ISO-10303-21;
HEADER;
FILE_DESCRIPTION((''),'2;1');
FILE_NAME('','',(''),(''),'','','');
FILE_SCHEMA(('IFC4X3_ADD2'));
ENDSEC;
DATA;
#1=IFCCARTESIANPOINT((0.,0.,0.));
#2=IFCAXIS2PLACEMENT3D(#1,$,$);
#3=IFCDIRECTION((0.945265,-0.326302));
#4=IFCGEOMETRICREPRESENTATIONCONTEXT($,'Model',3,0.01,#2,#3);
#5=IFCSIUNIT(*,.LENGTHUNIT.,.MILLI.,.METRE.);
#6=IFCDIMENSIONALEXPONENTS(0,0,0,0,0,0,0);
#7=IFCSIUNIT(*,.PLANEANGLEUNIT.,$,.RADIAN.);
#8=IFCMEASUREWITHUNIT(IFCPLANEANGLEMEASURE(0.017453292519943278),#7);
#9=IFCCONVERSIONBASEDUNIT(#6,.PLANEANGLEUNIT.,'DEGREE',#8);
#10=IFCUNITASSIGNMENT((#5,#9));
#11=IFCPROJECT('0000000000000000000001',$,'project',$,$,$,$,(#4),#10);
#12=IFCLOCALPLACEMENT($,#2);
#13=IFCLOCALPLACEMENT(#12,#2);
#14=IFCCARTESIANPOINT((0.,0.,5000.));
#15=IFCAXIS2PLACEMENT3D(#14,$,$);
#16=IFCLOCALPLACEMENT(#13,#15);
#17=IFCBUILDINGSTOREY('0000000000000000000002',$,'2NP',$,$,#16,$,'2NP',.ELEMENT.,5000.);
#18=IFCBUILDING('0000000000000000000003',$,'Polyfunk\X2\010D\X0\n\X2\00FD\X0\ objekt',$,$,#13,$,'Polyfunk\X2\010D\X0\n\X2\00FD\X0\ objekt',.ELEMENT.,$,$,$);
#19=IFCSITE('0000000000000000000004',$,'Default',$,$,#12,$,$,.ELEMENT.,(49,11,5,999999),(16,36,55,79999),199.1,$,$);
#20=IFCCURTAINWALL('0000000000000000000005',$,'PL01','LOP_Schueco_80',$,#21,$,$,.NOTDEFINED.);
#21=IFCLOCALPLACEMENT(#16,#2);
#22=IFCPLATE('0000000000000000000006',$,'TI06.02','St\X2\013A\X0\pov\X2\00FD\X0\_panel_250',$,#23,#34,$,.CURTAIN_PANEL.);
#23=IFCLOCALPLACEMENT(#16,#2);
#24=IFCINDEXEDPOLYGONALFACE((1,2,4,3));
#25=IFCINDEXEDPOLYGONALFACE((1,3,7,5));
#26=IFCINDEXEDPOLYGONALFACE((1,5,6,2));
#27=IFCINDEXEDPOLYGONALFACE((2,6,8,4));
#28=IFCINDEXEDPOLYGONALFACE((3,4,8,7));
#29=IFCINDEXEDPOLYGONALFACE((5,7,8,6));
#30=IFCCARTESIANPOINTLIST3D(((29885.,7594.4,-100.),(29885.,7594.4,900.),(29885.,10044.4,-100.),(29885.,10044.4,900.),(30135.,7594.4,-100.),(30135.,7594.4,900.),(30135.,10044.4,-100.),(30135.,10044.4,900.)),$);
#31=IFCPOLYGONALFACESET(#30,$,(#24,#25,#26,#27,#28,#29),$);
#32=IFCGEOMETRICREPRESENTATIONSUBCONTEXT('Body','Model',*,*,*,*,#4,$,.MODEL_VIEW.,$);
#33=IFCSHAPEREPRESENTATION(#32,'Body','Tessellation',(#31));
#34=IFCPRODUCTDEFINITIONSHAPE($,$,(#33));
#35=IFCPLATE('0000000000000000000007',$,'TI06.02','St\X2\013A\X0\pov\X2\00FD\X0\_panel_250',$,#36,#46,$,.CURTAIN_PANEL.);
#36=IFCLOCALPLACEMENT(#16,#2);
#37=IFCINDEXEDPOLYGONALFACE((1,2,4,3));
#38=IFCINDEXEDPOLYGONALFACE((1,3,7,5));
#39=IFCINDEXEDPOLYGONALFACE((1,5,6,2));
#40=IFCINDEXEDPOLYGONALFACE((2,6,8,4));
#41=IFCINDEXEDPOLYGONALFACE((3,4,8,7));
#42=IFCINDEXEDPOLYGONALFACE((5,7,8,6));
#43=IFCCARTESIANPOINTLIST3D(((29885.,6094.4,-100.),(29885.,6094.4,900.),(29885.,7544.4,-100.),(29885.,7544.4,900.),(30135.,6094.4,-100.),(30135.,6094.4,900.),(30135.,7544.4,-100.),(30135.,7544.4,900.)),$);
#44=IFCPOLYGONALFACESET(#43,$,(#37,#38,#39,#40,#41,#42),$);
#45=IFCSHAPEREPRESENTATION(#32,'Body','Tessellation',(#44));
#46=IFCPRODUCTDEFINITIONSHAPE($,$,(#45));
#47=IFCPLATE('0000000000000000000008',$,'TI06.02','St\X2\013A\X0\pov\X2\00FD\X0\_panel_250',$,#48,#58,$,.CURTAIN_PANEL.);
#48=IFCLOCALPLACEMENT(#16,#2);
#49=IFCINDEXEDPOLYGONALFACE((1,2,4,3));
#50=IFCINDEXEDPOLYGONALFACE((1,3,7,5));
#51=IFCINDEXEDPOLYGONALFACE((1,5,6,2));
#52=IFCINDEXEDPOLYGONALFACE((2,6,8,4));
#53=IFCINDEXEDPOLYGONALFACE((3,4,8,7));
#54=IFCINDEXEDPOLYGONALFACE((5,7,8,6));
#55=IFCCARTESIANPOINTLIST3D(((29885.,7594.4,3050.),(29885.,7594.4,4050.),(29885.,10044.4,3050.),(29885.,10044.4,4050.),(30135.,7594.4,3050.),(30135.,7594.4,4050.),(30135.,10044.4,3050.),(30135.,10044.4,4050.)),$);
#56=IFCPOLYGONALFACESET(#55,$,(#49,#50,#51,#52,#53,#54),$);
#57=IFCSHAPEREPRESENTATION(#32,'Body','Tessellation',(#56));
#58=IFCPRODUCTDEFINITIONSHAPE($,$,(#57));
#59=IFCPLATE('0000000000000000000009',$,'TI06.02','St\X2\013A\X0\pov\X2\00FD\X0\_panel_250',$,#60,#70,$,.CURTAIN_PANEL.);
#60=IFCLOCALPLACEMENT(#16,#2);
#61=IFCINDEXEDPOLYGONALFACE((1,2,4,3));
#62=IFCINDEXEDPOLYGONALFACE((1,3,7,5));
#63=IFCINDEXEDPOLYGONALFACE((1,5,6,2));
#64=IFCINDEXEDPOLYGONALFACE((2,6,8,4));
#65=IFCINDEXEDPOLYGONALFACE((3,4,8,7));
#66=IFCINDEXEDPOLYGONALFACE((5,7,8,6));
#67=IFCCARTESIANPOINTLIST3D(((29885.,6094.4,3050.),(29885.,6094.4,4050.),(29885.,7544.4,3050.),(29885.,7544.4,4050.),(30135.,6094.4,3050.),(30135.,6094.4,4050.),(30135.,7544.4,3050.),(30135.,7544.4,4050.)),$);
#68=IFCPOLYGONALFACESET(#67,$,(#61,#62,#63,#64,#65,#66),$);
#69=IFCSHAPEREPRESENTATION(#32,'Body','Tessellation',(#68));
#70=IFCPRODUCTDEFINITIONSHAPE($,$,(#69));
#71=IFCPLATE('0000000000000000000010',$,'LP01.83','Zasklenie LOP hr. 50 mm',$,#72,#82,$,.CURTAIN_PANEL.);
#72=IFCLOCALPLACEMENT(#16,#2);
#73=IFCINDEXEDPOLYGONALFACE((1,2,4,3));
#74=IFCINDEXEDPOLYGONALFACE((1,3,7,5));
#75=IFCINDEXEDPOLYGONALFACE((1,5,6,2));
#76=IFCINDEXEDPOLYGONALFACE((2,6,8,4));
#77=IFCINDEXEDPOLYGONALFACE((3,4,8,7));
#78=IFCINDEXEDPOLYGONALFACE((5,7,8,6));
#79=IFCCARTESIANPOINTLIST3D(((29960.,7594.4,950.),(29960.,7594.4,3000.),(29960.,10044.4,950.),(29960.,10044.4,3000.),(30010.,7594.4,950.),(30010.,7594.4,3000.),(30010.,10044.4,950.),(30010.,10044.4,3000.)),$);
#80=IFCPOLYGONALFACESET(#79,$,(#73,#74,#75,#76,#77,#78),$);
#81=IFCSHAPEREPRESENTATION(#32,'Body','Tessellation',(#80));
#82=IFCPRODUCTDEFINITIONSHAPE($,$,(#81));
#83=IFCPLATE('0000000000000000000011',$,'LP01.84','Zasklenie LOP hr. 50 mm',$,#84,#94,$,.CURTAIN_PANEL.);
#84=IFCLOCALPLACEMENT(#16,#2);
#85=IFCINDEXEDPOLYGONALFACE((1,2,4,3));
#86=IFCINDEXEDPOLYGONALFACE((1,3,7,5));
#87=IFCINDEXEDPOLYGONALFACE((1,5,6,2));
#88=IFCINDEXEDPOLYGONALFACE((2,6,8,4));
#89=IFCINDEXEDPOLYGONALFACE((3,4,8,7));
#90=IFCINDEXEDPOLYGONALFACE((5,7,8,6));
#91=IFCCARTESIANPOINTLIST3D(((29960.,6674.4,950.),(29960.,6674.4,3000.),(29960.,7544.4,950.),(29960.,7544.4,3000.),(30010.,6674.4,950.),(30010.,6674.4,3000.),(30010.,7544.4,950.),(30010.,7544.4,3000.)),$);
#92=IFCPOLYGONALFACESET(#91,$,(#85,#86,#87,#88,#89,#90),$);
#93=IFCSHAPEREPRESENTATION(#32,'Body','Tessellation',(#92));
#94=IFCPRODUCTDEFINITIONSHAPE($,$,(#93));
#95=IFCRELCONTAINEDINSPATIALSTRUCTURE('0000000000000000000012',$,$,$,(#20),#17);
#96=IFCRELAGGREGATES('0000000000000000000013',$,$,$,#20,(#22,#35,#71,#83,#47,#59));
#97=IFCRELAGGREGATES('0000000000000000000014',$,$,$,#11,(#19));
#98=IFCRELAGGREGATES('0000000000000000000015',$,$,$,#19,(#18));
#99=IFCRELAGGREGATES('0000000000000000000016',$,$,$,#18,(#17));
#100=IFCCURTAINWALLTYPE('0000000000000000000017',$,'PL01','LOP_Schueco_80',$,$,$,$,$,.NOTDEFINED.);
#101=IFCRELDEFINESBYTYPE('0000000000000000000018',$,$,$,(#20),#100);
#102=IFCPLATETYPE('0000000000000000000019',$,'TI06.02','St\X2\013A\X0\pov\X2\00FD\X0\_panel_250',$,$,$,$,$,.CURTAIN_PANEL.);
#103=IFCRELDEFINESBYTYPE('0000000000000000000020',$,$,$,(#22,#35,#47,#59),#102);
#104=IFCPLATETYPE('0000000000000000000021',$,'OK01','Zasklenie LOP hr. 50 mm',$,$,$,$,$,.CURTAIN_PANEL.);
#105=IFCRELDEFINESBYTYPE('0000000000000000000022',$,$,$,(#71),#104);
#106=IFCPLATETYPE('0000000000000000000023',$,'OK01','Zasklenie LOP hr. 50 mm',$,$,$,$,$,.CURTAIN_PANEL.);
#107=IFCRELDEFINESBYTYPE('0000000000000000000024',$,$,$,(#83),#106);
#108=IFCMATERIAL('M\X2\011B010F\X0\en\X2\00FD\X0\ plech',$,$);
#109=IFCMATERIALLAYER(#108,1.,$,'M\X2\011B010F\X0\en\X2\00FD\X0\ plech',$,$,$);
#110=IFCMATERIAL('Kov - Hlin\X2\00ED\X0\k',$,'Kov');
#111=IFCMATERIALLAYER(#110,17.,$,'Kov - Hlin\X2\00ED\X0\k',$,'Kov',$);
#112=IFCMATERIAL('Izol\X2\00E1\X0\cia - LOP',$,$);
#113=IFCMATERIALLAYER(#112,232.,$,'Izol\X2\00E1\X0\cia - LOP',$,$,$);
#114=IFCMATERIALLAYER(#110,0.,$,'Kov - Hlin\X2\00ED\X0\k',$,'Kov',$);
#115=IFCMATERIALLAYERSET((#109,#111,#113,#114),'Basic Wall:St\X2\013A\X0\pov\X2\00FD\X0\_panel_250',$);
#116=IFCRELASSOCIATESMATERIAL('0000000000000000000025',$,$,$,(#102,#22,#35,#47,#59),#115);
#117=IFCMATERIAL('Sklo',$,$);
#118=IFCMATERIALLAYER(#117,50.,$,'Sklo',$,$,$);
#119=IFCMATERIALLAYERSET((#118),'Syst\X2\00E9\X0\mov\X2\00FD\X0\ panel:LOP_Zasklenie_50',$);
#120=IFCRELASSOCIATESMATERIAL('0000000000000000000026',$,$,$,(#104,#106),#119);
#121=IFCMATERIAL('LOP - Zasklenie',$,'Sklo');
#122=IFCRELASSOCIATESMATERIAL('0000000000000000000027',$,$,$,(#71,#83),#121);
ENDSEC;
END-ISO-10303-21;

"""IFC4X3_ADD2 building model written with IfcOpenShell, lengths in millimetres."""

from ifc_helpers import new_model, entity, si_unit, converted_unit, direction, frame, frame_2d, origin, origin_2d_with_axis, place, context, subcontext, project, spatial, rectangle, extrude, source, transform, mapped, material, layer, layer_set, layer_usage, type_object, type_shapes, element, aggregate, save


model = new_model("IFC4X3_ADD2")

# Units and contexts
model_context = context("Model", 3, precision=0.01, world=origin(), true_north=direction((0.945265, -0.326302)))
body_context = subcontext(model_context, "Body", "Model", "MODEL_VIEW")
ifc_project = project(units=[si_unit("LENGTHUNIT", "METRE", prefix="MILLI"), converted_unit("PLANEANGLEUNIT", "DEGREE", entity("IfcPlaneAngleMeasure", 0.017453292519943278), si_unit("PLANEANGLEUNIT", "RADIAN"), dimensions=[0, 0, 0, 0, 0, 0, 0])], contexts=[model_context])

# Site, building, storey
site_placement = place(None, origin())
site = spatial("IfcSite", under=ifc_project, at=site_placement, Name="Default", CompositionType="ELEMENT", RefLatitude=(49, 11, 5, 999999), RefLongitude=(16, 36, 55, 79999), RefElevation=199.1)
building_placement = place(site_placement, origin())
building = spatial("IfcBuilding", under=site, at=building_placement, Name="Polyfunkčný objekt", LongName="Polyfunkčný objekt", CompositionType="ELEMENT")
storey_placement = place(building_placement, frame((0.0, 0.0, 5000.0)))
storey = spatial("IfcBuildingStorey", under=building, at=storey_placement, Name="2NP", LongName="2NP", CompositionType="ELEMENT", Elevation=5000.0)

# Curtain wall, plates
curtain_wall_type = type_object("IfcCurtainWallType", Name="PL01", Description="LOP_Schueco_80", PredefinedType="NOTDEFINED")
curtain_wall_placement = place(storey_placement, frame((0.0, 0.0, -5000.0)))
curtain_wall = element("IfcCurtainWall", 1, at=curtain_wall_placement, inside=storey, type_object=curtain_wall_type, Name="PL01", Description="LOP_Schueco_80", PredefinedType="NOTDEFINED")
ifc_material_1 = material(Name="Měďený plech")
ifc_layer_1 = layer(ifc_material_1, 1.0, Name="Měďený plech")
ifc_material_2 = material(Name="Kov - Hliník", Category="Kov")
ifc_layer_2 = layer(ifc_material_2, 17.0, Name="Kov - Hliník", Category="Kov")
ifc_material_3 = material(Name="Izolácia - LOP")
ifc_layer_3 = layer(ifc_material_3, 232.0, Name="Izolácia - LOP")
ifc_layer_4 = layer(ifc_material_2, 0.0, Name="Kov - Hliník", Category="Kov")
ifc_layer_set_1 = layer_set([ifc_layer_1, ifc_layer_2, ifc_layer_3, ifc_layer_4], Name="Basic Wall:Stĺpový_panel_250")
ifc_layer_usage_1 = layer_usage(ifc_layer_set_1, "AXIS2", "POSITIVE", -125.0)
plate_type_1 = type_object("IfcPlateType", Name="TI06.02", Description="Stĺpový_panel_250", PredefinedType="CURTAIN_PANEL", material=ifc_layer_set_1)
plate_1_placement = place(storey_placement, frame((30010.0, 10044.4, -100.0), z_axis=(0.0, 0.0, 1.0), x_axis=(0.0, -1.0, 0.0)))
plate_1 = element("IfcPlate", 2, at=plate_1_placement, type_object=plate_type_1, material=ifc_layer_usage_1, Name="TI06.02", Description="Stĺpový_panel_250", PredefinedType="CURTAIN_PANEL", context=body_context, shape_type="SweptSolid", body=[
    extrude(rectangle(XDim=250.0, YDim=2450.0, at=origin_2d_with_axis()), frame((1225.0, 0.0, 0.0), z_axis=(0.0, 0.0, 1.0), x_axis=(0.0, 1.0, 0.0)), (0.0, 0.0, 1.0), 1000.0),
])
ifc_layer_usage_2 = layer_usage(ifc_layer_set_1, "AXIS2", "POSITIVE", -125.0)
plate_2_placement = place(storey_placement, frame((30010.0, 7544.4, -100.0), z_axis=(0.0, 0.0, 1.0), x_axis=(0.0, -1.0, 0.0)))
plate_2 = element("IfcPlate", 3, at=plate_2_placement, type_object=plate_type_1, material=ifc_layer_usage_2, Name="TI06.02", Description="Stĺpový_panel_250", PredefinedType="CURTAIN_PANEL", context=body_context, shape_type="SweptSolid", body=[
    extrude(rectangle(XDim=250.0, YDim=1450.0, at=frame_2d((0.0, 0.0), x_axis=(1.0, 0.0))), frame((725.0, 0.0, 0.0), z_axis=(0.0, 0.0, 1.0), x_axis=(0.0, 1.0, 0.0)), (0.0, 0.0, 1.0), 1000.0),
])
ifc_layer_usage_3 = layer_usage(ifc_layer_set_1, "AXIS2", "POSITIVE", -125.0)
plate_3_placement = place(storey_placement, frame((30010.0, 10044.4, 3050.0), z_axis=(0.0, 0.0, 1.0), x_axis=(0.0, -1.0, 0.0)))
plate_3 = element("IfcPlate", 4, at=plate_3_placement, type_object=plate_type_1, material=ifc_layer_usage_3, Name="TI06.02", Description="Stĺpový_panel_250", PredefinedType="CURTAIN_PANEL", context=body_context, shape_type="SweptSolid", body=[
    extrude(rectangle(XDim=250.0, YDim=2450.0, at=origin_2d_with_axis()), frame((1225.0, 0.0, 0.0), z_axis=(0.0, 0.0, 1.0), x_axis=(0.0, 1.0, 0.0)), (0.0, 0.0, 1.0), 1000.0),
])
ifc_layer_usage_4 = layer_usage(ifc_layer_set_1, "AXIS2", "POSITIVE", -125.0)
plate_4_placement = place(storey_placement, frame((30010.0, 7544.4, 3050.0), z_axis=(0.0, 0.0, 1.0), x_axis=(0.0, -1.0, 0.0)))
plate_4 = element("IfcPlate", 5, at=plate_4_placement, type_object=plate_type_1, material=ifc_layer_usage_4, Name="TI06.02", Description="Stĺpový_panel_250", PredefinedType="CURTAIN_PANEL", context=body_context, shape_type="SweptSolid", body=[
    extrude(rectangle(XDim=250.0, YDim=1450.0, at=frame_2d((0.0, 0.0), x_axis=(1.0, 0.0))), frame((725.0, 0.0, 0.0), z_axis=(0.0, 0.0, 1.0), x_axis=(0.0, 1.0, 0.0)), (0.0, 0.0, 1.0), 1000.0),
])
ifc_material_4 = material(Name="LOP - Zasklenie", Category="Sklo")
ifc_material_5 = material(Name="Sklo")
ifc_layer_5 = layer(ifc_material_5, 50.0, Name="Sklo")
ifc_layer_set_2 = layer_set([ifc_layer_5], Name="Systémový panel:LOP_Zasklenie_50")
plate_type_2 = type_object("IfcPlateType", Name="OK01", Description="Zasklenie LOP hr. 50 mm", PredefinedType="CURTAIN_PANEL", material=ifc_layer_set_2)
shared_shape_1 = source(origin(), body_context, "Body", "SweptSolid", [
    extrude(rectangle(XDim=50.0, YDim=2450.0, at=origin_2d_with_axis()), frame((0.0, -25.0, 0.0), z_axis=(0.0, 0.0, 1.0), x_axis=(0.0, 1.0, 0.0)), (0.0, 0.0, 1.0), 2050.0),
])
type_shapes(plate_type_2, [shared_shape_1])
plate_5_placement = place(curtain_wall_placement, frame((30010.0, 8819.4, 5950.0), z_axis=(0.0, 0.0, 1.0), x_axis=(0.0, -1.0, 0.0)))
plate_5 = element("IfcPlate", 6, at=plate_5_placement, type_object=plate_type_2, material=ifc_material_4, Name="LP01.83", Description="Zasklenie LOP hr. 50 mm", PredefinedType="CURTAIN_PANEL", context=body_context, shape_type="MappedRepresentation", body=[
    mapped(shared_shape_1, transform((0.0, 0.0, 0.0), scale=1.0)),
])
plate_type_3 = type_object("IfcPlateType", Name="OK01", Description="Zasklenie LOP hr. 50 mm", PredefinedType="CURTAIN_PANEL", material=ifc_layer_set_2)
shared_shape_2 = source(origin(), body_context, "Body", "SweptSolid", [
    extrude(rectangle(XDim=50.0, YDim=870.0, at=origin_2d_with_axis()), frame((0.0, -25.0, 0.0), z_axis=(0.0, 0.0, 1.0), x_axis=(0.0, 1.0, 0.0)), (0.0, 0.0, 1.0), 2050.0),
])
type_shapes(plate_type_3, [shared_shape_2])
plate_6_placement = place(curtain_wall_placement, frame((30010.0, 7109.4, 5950.0), z_axis=(0.0, 0.0, 1.0), x_axis=(0.0, -1.0, 0.0)))
plate_6 = element("IfcPlate", 7, at=plate_6_placement, type_object=plate_type_3, material=ifc_material_4, Name="LP01.84", Description="Zasklenie LOP hr. 50 mm", PredefinedType="CURTAIN_PANEL", context=body_context, shape_type="MappedRepresentation", body=[
    mapped(shared_shape_2, transform((0.0, 0.0, 0.0), scale=1.0)),
])
aggregate(curtain_wall, [plate_1, plate_2, plate_5, plate_6, plate_3, plate_4])

save(model, "model.ifc")
